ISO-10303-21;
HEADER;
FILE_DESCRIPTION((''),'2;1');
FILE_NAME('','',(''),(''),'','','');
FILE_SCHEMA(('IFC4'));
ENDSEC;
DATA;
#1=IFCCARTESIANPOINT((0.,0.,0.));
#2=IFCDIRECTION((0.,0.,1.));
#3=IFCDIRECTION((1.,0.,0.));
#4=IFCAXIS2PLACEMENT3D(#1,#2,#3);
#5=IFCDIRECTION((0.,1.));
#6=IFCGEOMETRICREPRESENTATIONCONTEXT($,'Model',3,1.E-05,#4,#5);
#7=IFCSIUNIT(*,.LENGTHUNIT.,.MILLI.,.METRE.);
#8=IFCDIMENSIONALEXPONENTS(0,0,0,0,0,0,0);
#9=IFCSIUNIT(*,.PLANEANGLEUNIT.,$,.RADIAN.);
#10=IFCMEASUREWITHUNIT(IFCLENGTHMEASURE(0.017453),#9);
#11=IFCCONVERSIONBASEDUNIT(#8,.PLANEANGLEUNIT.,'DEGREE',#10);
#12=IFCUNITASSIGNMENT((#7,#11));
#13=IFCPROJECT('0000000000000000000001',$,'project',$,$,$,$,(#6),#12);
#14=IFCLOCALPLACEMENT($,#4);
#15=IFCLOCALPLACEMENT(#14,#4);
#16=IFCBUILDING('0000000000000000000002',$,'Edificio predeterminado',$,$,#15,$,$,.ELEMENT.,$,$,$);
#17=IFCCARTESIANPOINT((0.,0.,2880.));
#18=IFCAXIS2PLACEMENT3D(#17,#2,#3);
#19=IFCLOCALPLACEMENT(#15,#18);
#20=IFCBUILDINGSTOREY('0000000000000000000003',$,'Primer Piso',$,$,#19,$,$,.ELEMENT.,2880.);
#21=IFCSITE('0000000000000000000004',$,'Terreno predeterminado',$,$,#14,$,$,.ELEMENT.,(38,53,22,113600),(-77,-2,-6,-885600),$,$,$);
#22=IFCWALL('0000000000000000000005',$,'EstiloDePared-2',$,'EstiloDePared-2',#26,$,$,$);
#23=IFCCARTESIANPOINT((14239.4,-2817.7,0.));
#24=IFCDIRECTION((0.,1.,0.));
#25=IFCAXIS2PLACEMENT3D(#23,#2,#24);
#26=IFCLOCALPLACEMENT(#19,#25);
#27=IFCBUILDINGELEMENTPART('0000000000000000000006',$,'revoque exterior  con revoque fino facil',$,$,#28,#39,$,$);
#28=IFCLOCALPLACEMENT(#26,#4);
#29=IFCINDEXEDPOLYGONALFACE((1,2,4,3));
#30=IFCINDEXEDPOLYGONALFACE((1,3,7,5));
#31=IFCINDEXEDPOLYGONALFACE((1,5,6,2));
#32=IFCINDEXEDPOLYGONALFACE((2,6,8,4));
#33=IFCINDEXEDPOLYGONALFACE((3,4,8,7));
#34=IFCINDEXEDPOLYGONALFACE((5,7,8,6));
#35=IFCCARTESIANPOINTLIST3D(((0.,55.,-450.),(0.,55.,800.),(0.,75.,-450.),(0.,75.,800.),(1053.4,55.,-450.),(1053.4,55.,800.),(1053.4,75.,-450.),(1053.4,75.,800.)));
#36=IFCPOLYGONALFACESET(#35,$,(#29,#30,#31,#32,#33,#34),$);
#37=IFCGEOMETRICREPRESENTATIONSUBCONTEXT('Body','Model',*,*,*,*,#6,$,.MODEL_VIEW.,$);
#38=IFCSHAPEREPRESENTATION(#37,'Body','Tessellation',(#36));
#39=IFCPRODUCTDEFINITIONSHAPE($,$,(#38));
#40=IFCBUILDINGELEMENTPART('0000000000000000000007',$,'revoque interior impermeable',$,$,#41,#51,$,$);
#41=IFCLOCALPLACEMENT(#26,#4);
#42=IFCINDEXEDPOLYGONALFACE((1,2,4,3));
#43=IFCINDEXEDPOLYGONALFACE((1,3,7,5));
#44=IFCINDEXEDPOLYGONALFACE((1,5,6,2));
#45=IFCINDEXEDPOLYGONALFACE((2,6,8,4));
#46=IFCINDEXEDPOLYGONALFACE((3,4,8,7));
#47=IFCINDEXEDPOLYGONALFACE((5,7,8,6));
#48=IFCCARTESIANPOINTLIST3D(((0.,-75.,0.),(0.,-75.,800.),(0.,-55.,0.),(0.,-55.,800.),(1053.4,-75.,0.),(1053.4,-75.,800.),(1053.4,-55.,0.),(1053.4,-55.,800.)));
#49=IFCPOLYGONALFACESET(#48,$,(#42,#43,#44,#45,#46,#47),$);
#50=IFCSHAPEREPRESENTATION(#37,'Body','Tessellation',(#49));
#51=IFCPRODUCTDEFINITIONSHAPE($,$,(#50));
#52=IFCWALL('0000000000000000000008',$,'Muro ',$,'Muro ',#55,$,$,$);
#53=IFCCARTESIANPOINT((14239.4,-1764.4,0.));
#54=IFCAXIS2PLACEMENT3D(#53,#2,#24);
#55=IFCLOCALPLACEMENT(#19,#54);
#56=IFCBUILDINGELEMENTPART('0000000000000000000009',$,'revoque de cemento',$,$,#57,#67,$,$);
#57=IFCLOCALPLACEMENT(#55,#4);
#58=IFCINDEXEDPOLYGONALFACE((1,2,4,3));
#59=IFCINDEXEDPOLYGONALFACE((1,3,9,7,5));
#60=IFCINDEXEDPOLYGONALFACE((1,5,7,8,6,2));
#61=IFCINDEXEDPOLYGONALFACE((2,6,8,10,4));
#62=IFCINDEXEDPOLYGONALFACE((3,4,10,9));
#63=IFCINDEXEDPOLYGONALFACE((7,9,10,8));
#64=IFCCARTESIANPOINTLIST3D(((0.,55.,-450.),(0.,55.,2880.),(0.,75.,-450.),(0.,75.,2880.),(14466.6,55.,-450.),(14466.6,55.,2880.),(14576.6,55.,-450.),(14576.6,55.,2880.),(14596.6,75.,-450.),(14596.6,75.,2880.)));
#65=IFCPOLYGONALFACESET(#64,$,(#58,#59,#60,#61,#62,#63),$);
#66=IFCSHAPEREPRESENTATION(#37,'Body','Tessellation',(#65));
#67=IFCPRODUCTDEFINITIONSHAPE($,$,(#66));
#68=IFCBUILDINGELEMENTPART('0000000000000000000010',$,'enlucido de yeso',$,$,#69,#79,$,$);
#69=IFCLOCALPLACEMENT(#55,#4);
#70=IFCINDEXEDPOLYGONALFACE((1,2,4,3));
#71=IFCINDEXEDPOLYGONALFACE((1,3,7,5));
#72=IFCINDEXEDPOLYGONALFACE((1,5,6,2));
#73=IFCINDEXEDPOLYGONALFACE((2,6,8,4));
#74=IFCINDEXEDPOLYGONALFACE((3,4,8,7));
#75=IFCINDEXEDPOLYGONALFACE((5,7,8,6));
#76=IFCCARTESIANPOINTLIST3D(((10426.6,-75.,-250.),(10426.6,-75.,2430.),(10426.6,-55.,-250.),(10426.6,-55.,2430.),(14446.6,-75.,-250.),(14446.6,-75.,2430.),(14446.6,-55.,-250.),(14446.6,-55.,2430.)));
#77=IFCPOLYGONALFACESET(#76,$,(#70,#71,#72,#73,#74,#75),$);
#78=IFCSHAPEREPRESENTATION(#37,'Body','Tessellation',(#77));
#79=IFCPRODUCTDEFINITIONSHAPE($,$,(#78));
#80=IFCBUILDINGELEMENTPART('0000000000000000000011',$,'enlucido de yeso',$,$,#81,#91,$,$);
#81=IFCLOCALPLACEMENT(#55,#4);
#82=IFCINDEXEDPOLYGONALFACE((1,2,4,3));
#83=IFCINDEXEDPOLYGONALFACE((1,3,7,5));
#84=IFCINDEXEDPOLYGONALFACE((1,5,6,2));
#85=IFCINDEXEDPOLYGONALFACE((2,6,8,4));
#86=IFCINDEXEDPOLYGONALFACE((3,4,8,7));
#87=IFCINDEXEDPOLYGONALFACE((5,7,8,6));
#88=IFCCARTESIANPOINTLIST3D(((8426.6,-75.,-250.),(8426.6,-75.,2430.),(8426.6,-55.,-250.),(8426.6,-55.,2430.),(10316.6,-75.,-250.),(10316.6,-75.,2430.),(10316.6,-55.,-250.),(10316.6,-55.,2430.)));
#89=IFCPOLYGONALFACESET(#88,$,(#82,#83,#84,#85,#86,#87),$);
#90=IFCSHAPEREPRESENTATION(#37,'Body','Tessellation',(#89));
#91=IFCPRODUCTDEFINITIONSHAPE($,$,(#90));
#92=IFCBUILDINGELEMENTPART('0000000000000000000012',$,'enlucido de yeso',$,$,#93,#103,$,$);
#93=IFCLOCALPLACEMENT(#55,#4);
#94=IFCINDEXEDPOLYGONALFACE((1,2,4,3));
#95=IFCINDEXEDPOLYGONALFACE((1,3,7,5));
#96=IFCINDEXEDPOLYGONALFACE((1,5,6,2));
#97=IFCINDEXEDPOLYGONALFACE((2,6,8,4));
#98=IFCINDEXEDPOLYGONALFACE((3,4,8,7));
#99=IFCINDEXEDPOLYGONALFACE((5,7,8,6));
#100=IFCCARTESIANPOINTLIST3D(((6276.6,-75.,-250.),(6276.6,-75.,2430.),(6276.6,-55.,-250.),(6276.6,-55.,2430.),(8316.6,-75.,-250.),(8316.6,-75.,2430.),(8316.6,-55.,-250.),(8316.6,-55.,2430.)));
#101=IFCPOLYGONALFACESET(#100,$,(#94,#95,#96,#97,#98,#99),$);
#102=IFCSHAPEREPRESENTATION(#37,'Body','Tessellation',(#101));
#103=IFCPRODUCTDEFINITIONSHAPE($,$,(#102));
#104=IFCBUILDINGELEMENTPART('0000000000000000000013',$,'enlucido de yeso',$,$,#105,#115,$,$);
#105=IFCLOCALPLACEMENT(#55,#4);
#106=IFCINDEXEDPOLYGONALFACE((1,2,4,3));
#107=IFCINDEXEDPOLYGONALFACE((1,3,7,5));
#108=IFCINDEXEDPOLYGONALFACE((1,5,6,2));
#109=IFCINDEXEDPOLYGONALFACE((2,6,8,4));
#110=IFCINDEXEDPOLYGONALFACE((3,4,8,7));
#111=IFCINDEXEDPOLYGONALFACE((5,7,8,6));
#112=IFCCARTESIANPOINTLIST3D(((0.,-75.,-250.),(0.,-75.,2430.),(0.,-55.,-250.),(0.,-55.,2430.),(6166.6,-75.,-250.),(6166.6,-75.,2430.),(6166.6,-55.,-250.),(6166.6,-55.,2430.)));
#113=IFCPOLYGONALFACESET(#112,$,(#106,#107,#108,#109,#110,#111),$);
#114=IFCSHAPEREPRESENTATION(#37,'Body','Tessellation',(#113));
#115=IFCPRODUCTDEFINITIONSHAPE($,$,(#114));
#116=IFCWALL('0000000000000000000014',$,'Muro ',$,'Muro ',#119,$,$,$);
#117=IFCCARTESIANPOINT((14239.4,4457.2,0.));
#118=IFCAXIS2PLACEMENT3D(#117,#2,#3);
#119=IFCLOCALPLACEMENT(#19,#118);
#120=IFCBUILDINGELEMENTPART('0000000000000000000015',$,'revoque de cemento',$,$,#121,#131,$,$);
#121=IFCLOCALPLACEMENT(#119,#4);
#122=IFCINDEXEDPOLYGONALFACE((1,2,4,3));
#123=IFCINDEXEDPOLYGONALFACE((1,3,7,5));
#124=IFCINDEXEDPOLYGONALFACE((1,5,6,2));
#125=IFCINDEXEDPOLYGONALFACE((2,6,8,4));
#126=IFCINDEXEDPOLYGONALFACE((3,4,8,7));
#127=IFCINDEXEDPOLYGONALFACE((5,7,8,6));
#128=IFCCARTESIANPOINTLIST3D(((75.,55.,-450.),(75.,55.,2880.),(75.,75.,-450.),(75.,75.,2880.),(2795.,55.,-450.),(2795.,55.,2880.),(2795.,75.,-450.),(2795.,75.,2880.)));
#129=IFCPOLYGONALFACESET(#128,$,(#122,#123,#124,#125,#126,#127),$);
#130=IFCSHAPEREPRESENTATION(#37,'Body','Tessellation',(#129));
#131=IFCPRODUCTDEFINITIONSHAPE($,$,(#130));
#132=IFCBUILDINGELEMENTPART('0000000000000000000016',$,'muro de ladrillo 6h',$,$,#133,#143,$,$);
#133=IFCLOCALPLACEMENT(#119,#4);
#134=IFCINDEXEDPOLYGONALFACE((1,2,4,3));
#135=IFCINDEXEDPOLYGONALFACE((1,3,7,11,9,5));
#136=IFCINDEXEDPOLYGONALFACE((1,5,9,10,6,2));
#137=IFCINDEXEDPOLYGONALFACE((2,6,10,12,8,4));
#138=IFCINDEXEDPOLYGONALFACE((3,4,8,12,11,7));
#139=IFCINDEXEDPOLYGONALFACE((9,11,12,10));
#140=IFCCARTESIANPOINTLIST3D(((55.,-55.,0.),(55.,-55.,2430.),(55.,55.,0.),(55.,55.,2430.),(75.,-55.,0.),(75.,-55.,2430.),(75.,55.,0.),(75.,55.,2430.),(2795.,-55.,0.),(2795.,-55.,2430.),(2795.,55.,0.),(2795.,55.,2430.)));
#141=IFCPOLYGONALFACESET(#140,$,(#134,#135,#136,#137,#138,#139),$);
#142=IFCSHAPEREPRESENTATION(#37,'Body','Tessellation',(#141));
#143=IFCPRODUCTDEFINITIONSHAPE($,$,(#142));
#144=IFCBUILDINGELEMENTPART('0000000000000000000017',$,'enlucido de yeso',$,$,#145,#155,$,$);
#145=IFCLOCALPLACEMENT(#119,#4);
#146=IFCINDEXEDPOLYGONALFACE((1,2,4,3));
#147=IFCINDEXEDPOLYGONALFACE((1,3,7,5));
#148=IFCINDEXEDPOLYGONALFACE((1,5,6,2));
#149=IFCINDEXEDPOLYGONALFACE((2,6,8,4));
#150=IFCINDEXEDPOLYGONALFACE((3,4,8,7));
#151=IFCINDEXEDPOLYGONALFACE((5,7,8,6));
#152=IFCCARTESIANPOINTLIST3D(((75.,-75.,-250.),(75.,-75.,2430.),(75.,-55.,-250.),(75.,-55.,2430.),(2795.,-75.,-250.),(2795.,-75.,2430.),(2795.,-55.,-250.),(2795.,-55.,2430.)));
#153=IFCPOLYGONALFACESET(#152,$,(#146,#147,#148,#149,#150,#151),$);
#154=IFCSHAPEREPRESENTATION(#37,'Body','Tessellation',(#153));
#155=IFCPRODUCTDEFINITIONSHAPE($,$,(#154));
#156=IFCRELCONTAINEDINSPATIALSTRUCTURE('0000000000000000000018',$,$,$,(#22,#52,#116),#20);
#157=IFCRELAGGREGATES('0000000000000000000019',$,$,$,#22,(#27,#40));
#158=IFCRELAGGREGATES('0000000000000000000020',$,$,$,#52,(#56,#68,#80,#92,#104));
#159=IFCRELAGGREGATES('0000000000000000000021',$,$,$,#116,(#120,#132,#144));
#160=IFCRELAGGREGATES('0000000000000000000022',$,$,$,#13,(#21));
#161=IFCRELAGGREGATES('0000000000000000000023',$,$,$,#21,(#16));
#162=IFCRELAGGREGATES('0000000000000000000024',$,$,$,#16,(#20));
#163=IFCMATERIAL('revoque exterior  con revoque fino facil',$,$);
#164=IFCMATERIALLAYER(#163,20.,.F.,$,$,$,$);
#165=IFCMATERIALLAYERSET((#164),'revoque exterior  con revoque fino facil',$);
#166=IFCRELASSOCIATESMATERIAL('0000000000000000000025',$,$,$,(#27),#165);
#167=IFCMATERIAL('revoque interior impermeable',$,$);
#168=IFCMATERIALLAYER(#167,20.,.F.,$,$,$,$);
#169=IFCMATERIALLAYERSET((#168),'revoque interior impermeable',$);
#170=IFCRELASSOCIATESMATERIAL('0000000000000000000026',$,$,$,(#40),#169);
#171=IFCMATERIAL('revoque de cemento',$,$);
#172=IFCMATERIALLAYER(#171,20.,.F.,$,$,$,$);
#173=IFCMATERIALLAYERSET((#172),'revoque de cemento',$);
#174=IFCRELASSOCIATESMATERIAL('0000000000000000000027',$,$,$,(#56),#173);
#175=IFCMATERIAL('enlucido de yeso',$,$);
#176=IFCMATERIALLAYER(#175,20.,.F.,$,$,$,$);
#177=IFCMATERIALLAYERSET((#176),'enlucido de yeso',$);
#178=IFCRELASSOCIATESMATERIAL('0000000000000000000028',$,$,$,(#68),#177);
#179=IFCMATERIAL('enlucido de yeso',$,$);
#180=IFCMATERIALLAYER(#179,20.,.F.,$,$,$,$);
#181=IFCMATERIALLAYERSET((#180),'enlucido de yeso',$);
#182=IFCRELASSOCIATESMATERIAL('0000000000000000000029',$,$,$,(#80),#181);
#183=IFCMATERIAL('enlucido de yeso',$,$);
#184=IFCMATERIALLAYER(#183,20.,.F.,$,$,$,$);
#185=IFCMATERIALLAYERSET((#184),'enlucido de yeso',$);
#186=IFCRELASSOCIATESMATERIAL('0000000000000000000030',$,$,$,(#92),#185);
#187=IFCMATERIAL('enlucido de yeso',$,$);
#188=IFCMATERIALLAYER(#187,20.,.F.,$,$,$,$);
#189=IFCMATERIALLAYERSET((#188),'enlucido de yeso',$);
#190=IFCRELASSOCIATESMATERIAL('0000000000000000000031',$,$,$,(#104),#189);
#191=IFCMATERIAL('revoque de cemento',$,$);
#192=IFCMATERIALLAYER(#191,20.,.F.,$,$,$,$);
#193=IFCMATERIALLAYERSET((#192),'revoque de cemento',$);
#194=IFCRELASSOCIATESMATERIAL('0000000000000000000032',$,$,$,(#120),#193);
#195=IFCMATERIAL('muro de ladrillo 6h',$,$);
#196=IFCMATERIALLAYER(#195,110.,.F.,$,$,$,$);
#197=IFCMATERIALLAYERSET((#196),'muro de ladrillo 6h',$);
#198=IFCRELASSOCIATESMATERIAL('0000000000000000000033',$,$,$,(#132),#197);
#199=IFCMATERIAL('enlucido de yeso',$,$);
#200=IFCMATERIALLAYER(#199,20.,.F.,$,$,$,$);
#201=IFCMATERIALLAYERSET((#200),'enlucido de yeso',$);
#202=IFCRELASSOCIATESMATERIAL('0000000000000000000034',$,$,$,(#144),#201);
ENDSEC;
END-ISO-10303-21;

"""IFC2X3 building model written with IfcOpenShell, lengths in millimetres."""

from ifc_helpers import new_model, entity, si_unit, converted_unit, direction, frame, origin_with_axes, place, context, subcontext, project, spatial, polyline, outline, extrude, material, layer, layer_set, layer_usage, element, aggregate, save


model = new_model("IFC2X3")

# Units and contexts
model_context = context("Model", 3, precision=1e-05, world=origin_with_axes(), true_north=direction((0.0, 1.0)))
body_context = subcontext(model_context, "Body", "Model", "MODEL_VIEW")
ifc_project = project(units=[si_unit("LENGTHUNIT", "METRE", prefix="MILLI"), converted_unit("PLANEANGLEUNIT", "DEGREE", entity("IfcLengthMeasure", 0.017453), si_unit("PLANEANGLEUNIT", "RADIAN"), dimensions=[0, 0, 0, 0, 0, 0, 0])], contexts=[model_context])

# Site, building, storey
site_placement = place(None, origin_with_axes())
site = spatial("IfcSite", under=ifc_project, at=site_placement, Name="Terreno predeterminado", CompositionType="ELEMENT", RefLatitude=(38, 53, 22, 113600), RefLongitude=(-77, -2, -6, -885600))
building_placement = place(site_placement, origin_with_axes())
building = spatial("IfcBuilding", under=site, at=building_placement, Name="Edificio predeterminado", CompositionType="ELEMENT")
storey_placement = place(building_placement, frame((0.0, 0.0, 2880.0), z_axis=(0.0, 0.0, 1.0), x_axis=(1.0, 0.0, 0.0)))
storey = spatial("IfcBuildingStorey", under=building, at=storey_placement, Name="Primer Piso", CompositionType="ELEMENT", Elevation=2880.0)

# Walls, building element parts
wall_1_placement = place(storey_placement, frame((14239.4, -2817.7, 0.0), z_axis=(0.0, 0.0, 1.0), x_axis=(0.0, 1.0, 0.0)))
wall_1 = element("IfcWall", 1, at=wall_1_placement, inside=storey, Name="EstiloDePared-2", ObjectType="EstiloDePared-2")
ifc_material_1 = material(Name="revoque exterior  con revoque fino facil")
ifc_layer_1 = layer(ifc_material_1, 20.0, ventilated=False)
ifc_layer_set_1 = layer_set([ifc_layer_1], Name="revoque exterior  con revoque fino facil")
ifc_layer_usage_1 = layer_usage(ifc_layer_set_1, "AXIS2", "NEGATIVE", -75.0)
building_element_part_1_placement = place(wall_1_placement, origin_with_axes())
building_element_part_1 = element("IfcBuildingElementPart", 2, at=building_element_part_1_placement, material=ifc_layer_usage_1, Name="revoque exterior  con revoque fino facil", context=body_context, shape_type="SweptSolid", body=[
    extrude(outline(polyline([(1053.4, 75.0), (1053.4, 55.0), (0.0, 55.0), (0.0, 75.0), (1053.4, 75.0)])), frame((0.0, 0.0, -450.0), z_axis=(0.0, 0.0, 1.0), x_axis=(1.0, 0.0, 0.0)), (0.0, 0.0, 1.0), 1250.0),
])
ifc_material_2 = material(Name="revoque interior impermeable")
ifc_layer_2 = layer(ifc_material_2, 20.0, ventilated=False)
ifc_layer_set_2 = layer_set([ifc_layer_2], Name="revoque interior impermeable")
ifc_layer_usage_2 = layer_usage(ifc_layer_set_2, "AXIS2", "NEGATIVE", 55.0)
building_element_part_2_placement = place(wall_1_placement, origin_with_axes())
building_element_part_2 = element("IfcBuildingElementPart", 3, at=building_element_part_2_placement, material=ifc_layer_usage_2, Name="revoque interior impermeable", context=body_context, shape_type="SweptSolid", body=[
    extrude(outline(polyline([(1053.4, -55.0), (1053.4, -75.0), (0.0, -75.0), (0.0, -55.0), (1053.4, -55.0)])), origin_with_axes(), (0.0, 0.0, 1.0), 800.0),
])
aggregate(wall_1, [building_element_part_1, building_element_part_2])
wall_2_placement = place(storey_placement, frame((14239.4, -1764.4, 0.0), z_axis=(0.0, 0.0, 1.0), x_axis=(0.0, 1.0, 0.0)))
wall_2 = element("IfcWall", 4, at=wall_2_placement, inside=storey, Name="Muro ", ObjectType="Muro ")
ifc_material_3 = material(Name="revoque de cemento")
ifc_layer_3 = layer(ifc_material_3, 20.0, ventilated=False)
ifc_layer_set_3 = layer_set([ifc_layer_3], Name="revoque de cemento")
ifc_layer_usage_3 = layer_usage(ifc_layer_set_3, "AXIS2", "NEGATIVE", -75.0)
building_element_part_3_placement = place(wall_2_placement, origin_with_axes())
building_element_part_3 = element("IfcBuildingElementPart", 5, at=building_element_part_3_placement, material=ifc_layer_usage_3, Name="revoque de cemento", context=body_context, shape_type="SweptSolid", body=[
    extrude(outline(polyline([(14596.6, 75.0), (14576.6, 55.0), (14466.6, 55.0), (0.0, 55.0), (0.0, 75.0), (14596.6, 75.0)])), frame((0.0, 0.0, -450.0), z_axis=(0.0, 0.0, 1.0), x_axis=(1.0, 0.0, 0.0)), (0.0, 0.0, 1.0), 3330.0),
])
ifc_material_4 = material(Name="enlucido de yeso")
ifc_layer_4 = layer(ifc_material_4, 20.0, ventilated=False)
ifc_layer_set_4 = layer_set([ifc_layer_4], Name="enlucido de yeso")
ifc_layer_usage_4 = layer_usage(ifc_layer_set_4, "AXIS2", "NEGATIVE", 55.0)
building_element_part_4_placement = place(wall_2_placement, origin_with_axes())
building_element_part_4 = element("IfcBuildingElementPart", 6, at=building_element_part_4_placement, material=ifc_layer_usage_4, Name="enlucido de yeso", context=body_context, shape_type="SweptSolid", body=[
    extrude(outline(polyline([(14446.6, -55.0), (14446.6, -75.0), (10426.6, -75.0), (10426.6, -55.0), (14446.6, -55.0)])), frame((0.0, 0.0, -250.0), z_axis=(0.0, 0.0, 1.0), x_axis=(1.0, 0.0, 0.0)), (0.0, 0.0, 1.0), 2680.0),
])
ifc_material_5 = material(Name="enlucido de yeso")
ifc_layer_5 = layer(ifc_material_5, 20.0, ventilated=False)
ifc_layer_set_5 = layer_set([ifc_layer_5], Name="enlucido de yeso")
ifc_layer_usage_5 = layer_usage(ifc_layer_set_5, "AXIS2", "NEGATIVE", 55.0)
building_element_part_5_placement = place(wall_2_placement, origin_with_axes())
building_element_part_5 = element("IfcBuildingElementPart", 7, at=building_element_part_5_placement, material=ifc_layer_usage_5, Name="enlucido de yeso", context=body_context, shape_type="SweptSolid", body=[
    extrude(outline(polyline([(10316.6, -55.0), (10316.6, -75.0), (8426.6, -75.0), (8426.6, -55.0), (10316.6, -55.0)])), frame((0.0, 0.0, -250.0), z_axis=(0.0, 0.0, 1.0), x_axis=(1.0, 0.0, 0.0)), (0.0, 0.0, 1.0), 2680.0),
])
ifc_material_6 = material(Name="enlucido de yeso")
ifc_layer_6 = layer(ifc_material_6, 20.0, ventilated=False)
ifc_layer_set_6 = layer_set([ifc_layer_6], Name="enlucido de yeso")
ifc_layer_usage_6 = layer_usage(ifc_layer_set_6, "AXIS2", "NEGATIVE", 55.0)
building_element_part_6_placement = place(wall_2_placement, origin_with_axes())
building_element_part_6 = element("IfcBuildingElementPart", 8, at=building_element_part_6_placement, material=ifc_layer_usage_6, Name="enlucido de yeso", context=body_context, shape_type="SweptSolid", body=[
    extrude(outline(polyline([(8316.6, -55.0), (8316.6, -75.0), (6276.6, -75.0), (6276.6, -55.0), (8316.6, -55.0)])), frame((0.0, 0.0, -250.0), z_axis=(0.0, 0.0, 1.0), x_axis=(1.0, 0.0, 0.0)), (0.0, 0.0, 1.0), 2680.0),
])
ifc_material_7 = material(Name="enlucido de yeso")
ifc_layer_7 = layer(ifc_material_7, 20.0, ventilated=False)
ifc_layer_set_7 = layer_set([ifc_layer_7], Name="enlucido de yeso")
ifc_layer_usage_7 = layer_usage(ifc_layer_set_7, "AXIS2", "NEGATIVE", 55.0)
building_element_part_7_placement = place(wall_2_placement, origin_with_axes())
building_element_part_7 = element("IfcBuildingElementPart", 9, at=building_element_part_7_placement, material=ifc_layer_usage_7, Name="enlucido de yeso", context=body_context, shape_type="SweptSolid", body=[
    extrude(outline(polyline([(6166.6, -55.0), (6166.6, -75.0), (0.0, -75.0), (0.0, -55.0), (6166.6, -55.0)])), frame((0.0, 0.0, -250.0), z_axis=(0.0, 0.0, 1.0), x_axis=(1.0, 0.0, 0.0)), (0.0, 0.0, 1.0), 2680.0),
])
aggregate(wall_2, [building_element_part_3, building_element_part_4, building_element_part_5, building_element_part_6, building_element_part_7])
wall_3_placement = place(storey_placement, frame((14239.4, 4457.2, 0.0), z_axis=(0.0, 0.0, 1.0), x_axis=(1.0, 0.0, 0.0)))
wall_3 = element("IfcWall", 10, at=wall_3_placement, inside=storey, Name="Muro ", ObjectType="Muro ")
ifc_material_8 = material(Name="revoque de cemento")
ifc_layer_8 = layer(ifc_material_8, 20.0, ventilated=False)
ifc_layer_set_8 = layer_set([ifc_layer_8], Name="revoque de cemento")
ifc_layer_usage_8 = layer_usage(ifc_layer_set_8, "AXIS2", "NEGATIVE", -75.0)
building_element_part_8_placement = place(wall_3_placement, origin_with_axes())
building_element_part_8 = element("IfcBuildingElementPart", 11, at=building_element_part_8_placement, material=ifc_layer_usage_8, Name="revoque de cemento", context=body_context, shape_type="SweptSolid", body=[
    extrude(outline(polyline([(2795.0, 75.0), (2795.0, 55.0), (75.0, 55.0), (75.0, 75.0), (2795.0, 75.0)])), frame((0.0, 0.0, -450.0), z_axis=(0.0, 0.0, 1.0), x_axis=(1.0, 0.0, 0.0)), (0.0, 0.0, 1.0), 3330.0),
])
ifc_material_9 = material(Name="muro de ladrillo 6h")
ifc_layer_9 = layer(ifc_material_9, 110.0, ventilated=False)
ifc_layer_set_9 = layer_set([ifc_layer_9], Name="muro de ladrillo 6h")
ifc_layer_usage_9 = layer_usage(ifc_layer_set_9, "AXIS2", "NEGATIVE", -55.0)
building_element_part_9_placement = place(wall_3_placement, origin_with_axes())
building_element_part_9 = element("IfcBuildingElementPart", 12, at=building_element_part_9_placement, material=ifc_layer_usage_9, Name="muro de ladrillo 6h", context=body_context, shape_type="SweptSolid", body=[
    extrude(outline(polyline([(2795.0, 55.0), (2795.0, -55.0), (75.0, -55.0), (55.0, -55.0), (55.0, 55.0), (75.0, 55.0), (2795.0, 55.0)])), origin_with_axes(), (0.0, 0.0, 1.0), 2430.0),
])
ifc_material_10 = material(Name="enlucido de yeso")
ifc_layer_10 = layer(ifc_material_10, 20.0, ventilated=False)
ifc_layer_set_10 = layer_set([ifc_layer_10], Name="enlucido de yeso")
ifc_layer_usage_10 = layer_usage(ifc_layer_set_10, "AXIS2", "NEGATIVE", 55.0)
building_element_part_10_placement = place(wall_3_placement, origin_with_axes())
building_element_part_10 = element("IfcBuildingElementPart", 13, at=building_element_part_10_placement, material=ifc_layer_usage_10, Name="enlucido de yeso", context=body_context, shape_type="SweptSolid", body=[
    extrude(outline(polyline([(75.0, -55.0), (2795.0, -55.0), (2795.0, -75.0), (75.0, -75.0), (75.0, -55.0)])), frame((0.0, 0.0, -250.0), z_axis=(0.0, 0.0, 1.0), x_axis=(1.0, 0.0, 0.0)), (0.0, 0.0, 1.0), 2680.0),
])
aggregate(wall_3, [building_element_part_8, building_element_part_9, building_element_part_10])

save(model, "model.ifc")
